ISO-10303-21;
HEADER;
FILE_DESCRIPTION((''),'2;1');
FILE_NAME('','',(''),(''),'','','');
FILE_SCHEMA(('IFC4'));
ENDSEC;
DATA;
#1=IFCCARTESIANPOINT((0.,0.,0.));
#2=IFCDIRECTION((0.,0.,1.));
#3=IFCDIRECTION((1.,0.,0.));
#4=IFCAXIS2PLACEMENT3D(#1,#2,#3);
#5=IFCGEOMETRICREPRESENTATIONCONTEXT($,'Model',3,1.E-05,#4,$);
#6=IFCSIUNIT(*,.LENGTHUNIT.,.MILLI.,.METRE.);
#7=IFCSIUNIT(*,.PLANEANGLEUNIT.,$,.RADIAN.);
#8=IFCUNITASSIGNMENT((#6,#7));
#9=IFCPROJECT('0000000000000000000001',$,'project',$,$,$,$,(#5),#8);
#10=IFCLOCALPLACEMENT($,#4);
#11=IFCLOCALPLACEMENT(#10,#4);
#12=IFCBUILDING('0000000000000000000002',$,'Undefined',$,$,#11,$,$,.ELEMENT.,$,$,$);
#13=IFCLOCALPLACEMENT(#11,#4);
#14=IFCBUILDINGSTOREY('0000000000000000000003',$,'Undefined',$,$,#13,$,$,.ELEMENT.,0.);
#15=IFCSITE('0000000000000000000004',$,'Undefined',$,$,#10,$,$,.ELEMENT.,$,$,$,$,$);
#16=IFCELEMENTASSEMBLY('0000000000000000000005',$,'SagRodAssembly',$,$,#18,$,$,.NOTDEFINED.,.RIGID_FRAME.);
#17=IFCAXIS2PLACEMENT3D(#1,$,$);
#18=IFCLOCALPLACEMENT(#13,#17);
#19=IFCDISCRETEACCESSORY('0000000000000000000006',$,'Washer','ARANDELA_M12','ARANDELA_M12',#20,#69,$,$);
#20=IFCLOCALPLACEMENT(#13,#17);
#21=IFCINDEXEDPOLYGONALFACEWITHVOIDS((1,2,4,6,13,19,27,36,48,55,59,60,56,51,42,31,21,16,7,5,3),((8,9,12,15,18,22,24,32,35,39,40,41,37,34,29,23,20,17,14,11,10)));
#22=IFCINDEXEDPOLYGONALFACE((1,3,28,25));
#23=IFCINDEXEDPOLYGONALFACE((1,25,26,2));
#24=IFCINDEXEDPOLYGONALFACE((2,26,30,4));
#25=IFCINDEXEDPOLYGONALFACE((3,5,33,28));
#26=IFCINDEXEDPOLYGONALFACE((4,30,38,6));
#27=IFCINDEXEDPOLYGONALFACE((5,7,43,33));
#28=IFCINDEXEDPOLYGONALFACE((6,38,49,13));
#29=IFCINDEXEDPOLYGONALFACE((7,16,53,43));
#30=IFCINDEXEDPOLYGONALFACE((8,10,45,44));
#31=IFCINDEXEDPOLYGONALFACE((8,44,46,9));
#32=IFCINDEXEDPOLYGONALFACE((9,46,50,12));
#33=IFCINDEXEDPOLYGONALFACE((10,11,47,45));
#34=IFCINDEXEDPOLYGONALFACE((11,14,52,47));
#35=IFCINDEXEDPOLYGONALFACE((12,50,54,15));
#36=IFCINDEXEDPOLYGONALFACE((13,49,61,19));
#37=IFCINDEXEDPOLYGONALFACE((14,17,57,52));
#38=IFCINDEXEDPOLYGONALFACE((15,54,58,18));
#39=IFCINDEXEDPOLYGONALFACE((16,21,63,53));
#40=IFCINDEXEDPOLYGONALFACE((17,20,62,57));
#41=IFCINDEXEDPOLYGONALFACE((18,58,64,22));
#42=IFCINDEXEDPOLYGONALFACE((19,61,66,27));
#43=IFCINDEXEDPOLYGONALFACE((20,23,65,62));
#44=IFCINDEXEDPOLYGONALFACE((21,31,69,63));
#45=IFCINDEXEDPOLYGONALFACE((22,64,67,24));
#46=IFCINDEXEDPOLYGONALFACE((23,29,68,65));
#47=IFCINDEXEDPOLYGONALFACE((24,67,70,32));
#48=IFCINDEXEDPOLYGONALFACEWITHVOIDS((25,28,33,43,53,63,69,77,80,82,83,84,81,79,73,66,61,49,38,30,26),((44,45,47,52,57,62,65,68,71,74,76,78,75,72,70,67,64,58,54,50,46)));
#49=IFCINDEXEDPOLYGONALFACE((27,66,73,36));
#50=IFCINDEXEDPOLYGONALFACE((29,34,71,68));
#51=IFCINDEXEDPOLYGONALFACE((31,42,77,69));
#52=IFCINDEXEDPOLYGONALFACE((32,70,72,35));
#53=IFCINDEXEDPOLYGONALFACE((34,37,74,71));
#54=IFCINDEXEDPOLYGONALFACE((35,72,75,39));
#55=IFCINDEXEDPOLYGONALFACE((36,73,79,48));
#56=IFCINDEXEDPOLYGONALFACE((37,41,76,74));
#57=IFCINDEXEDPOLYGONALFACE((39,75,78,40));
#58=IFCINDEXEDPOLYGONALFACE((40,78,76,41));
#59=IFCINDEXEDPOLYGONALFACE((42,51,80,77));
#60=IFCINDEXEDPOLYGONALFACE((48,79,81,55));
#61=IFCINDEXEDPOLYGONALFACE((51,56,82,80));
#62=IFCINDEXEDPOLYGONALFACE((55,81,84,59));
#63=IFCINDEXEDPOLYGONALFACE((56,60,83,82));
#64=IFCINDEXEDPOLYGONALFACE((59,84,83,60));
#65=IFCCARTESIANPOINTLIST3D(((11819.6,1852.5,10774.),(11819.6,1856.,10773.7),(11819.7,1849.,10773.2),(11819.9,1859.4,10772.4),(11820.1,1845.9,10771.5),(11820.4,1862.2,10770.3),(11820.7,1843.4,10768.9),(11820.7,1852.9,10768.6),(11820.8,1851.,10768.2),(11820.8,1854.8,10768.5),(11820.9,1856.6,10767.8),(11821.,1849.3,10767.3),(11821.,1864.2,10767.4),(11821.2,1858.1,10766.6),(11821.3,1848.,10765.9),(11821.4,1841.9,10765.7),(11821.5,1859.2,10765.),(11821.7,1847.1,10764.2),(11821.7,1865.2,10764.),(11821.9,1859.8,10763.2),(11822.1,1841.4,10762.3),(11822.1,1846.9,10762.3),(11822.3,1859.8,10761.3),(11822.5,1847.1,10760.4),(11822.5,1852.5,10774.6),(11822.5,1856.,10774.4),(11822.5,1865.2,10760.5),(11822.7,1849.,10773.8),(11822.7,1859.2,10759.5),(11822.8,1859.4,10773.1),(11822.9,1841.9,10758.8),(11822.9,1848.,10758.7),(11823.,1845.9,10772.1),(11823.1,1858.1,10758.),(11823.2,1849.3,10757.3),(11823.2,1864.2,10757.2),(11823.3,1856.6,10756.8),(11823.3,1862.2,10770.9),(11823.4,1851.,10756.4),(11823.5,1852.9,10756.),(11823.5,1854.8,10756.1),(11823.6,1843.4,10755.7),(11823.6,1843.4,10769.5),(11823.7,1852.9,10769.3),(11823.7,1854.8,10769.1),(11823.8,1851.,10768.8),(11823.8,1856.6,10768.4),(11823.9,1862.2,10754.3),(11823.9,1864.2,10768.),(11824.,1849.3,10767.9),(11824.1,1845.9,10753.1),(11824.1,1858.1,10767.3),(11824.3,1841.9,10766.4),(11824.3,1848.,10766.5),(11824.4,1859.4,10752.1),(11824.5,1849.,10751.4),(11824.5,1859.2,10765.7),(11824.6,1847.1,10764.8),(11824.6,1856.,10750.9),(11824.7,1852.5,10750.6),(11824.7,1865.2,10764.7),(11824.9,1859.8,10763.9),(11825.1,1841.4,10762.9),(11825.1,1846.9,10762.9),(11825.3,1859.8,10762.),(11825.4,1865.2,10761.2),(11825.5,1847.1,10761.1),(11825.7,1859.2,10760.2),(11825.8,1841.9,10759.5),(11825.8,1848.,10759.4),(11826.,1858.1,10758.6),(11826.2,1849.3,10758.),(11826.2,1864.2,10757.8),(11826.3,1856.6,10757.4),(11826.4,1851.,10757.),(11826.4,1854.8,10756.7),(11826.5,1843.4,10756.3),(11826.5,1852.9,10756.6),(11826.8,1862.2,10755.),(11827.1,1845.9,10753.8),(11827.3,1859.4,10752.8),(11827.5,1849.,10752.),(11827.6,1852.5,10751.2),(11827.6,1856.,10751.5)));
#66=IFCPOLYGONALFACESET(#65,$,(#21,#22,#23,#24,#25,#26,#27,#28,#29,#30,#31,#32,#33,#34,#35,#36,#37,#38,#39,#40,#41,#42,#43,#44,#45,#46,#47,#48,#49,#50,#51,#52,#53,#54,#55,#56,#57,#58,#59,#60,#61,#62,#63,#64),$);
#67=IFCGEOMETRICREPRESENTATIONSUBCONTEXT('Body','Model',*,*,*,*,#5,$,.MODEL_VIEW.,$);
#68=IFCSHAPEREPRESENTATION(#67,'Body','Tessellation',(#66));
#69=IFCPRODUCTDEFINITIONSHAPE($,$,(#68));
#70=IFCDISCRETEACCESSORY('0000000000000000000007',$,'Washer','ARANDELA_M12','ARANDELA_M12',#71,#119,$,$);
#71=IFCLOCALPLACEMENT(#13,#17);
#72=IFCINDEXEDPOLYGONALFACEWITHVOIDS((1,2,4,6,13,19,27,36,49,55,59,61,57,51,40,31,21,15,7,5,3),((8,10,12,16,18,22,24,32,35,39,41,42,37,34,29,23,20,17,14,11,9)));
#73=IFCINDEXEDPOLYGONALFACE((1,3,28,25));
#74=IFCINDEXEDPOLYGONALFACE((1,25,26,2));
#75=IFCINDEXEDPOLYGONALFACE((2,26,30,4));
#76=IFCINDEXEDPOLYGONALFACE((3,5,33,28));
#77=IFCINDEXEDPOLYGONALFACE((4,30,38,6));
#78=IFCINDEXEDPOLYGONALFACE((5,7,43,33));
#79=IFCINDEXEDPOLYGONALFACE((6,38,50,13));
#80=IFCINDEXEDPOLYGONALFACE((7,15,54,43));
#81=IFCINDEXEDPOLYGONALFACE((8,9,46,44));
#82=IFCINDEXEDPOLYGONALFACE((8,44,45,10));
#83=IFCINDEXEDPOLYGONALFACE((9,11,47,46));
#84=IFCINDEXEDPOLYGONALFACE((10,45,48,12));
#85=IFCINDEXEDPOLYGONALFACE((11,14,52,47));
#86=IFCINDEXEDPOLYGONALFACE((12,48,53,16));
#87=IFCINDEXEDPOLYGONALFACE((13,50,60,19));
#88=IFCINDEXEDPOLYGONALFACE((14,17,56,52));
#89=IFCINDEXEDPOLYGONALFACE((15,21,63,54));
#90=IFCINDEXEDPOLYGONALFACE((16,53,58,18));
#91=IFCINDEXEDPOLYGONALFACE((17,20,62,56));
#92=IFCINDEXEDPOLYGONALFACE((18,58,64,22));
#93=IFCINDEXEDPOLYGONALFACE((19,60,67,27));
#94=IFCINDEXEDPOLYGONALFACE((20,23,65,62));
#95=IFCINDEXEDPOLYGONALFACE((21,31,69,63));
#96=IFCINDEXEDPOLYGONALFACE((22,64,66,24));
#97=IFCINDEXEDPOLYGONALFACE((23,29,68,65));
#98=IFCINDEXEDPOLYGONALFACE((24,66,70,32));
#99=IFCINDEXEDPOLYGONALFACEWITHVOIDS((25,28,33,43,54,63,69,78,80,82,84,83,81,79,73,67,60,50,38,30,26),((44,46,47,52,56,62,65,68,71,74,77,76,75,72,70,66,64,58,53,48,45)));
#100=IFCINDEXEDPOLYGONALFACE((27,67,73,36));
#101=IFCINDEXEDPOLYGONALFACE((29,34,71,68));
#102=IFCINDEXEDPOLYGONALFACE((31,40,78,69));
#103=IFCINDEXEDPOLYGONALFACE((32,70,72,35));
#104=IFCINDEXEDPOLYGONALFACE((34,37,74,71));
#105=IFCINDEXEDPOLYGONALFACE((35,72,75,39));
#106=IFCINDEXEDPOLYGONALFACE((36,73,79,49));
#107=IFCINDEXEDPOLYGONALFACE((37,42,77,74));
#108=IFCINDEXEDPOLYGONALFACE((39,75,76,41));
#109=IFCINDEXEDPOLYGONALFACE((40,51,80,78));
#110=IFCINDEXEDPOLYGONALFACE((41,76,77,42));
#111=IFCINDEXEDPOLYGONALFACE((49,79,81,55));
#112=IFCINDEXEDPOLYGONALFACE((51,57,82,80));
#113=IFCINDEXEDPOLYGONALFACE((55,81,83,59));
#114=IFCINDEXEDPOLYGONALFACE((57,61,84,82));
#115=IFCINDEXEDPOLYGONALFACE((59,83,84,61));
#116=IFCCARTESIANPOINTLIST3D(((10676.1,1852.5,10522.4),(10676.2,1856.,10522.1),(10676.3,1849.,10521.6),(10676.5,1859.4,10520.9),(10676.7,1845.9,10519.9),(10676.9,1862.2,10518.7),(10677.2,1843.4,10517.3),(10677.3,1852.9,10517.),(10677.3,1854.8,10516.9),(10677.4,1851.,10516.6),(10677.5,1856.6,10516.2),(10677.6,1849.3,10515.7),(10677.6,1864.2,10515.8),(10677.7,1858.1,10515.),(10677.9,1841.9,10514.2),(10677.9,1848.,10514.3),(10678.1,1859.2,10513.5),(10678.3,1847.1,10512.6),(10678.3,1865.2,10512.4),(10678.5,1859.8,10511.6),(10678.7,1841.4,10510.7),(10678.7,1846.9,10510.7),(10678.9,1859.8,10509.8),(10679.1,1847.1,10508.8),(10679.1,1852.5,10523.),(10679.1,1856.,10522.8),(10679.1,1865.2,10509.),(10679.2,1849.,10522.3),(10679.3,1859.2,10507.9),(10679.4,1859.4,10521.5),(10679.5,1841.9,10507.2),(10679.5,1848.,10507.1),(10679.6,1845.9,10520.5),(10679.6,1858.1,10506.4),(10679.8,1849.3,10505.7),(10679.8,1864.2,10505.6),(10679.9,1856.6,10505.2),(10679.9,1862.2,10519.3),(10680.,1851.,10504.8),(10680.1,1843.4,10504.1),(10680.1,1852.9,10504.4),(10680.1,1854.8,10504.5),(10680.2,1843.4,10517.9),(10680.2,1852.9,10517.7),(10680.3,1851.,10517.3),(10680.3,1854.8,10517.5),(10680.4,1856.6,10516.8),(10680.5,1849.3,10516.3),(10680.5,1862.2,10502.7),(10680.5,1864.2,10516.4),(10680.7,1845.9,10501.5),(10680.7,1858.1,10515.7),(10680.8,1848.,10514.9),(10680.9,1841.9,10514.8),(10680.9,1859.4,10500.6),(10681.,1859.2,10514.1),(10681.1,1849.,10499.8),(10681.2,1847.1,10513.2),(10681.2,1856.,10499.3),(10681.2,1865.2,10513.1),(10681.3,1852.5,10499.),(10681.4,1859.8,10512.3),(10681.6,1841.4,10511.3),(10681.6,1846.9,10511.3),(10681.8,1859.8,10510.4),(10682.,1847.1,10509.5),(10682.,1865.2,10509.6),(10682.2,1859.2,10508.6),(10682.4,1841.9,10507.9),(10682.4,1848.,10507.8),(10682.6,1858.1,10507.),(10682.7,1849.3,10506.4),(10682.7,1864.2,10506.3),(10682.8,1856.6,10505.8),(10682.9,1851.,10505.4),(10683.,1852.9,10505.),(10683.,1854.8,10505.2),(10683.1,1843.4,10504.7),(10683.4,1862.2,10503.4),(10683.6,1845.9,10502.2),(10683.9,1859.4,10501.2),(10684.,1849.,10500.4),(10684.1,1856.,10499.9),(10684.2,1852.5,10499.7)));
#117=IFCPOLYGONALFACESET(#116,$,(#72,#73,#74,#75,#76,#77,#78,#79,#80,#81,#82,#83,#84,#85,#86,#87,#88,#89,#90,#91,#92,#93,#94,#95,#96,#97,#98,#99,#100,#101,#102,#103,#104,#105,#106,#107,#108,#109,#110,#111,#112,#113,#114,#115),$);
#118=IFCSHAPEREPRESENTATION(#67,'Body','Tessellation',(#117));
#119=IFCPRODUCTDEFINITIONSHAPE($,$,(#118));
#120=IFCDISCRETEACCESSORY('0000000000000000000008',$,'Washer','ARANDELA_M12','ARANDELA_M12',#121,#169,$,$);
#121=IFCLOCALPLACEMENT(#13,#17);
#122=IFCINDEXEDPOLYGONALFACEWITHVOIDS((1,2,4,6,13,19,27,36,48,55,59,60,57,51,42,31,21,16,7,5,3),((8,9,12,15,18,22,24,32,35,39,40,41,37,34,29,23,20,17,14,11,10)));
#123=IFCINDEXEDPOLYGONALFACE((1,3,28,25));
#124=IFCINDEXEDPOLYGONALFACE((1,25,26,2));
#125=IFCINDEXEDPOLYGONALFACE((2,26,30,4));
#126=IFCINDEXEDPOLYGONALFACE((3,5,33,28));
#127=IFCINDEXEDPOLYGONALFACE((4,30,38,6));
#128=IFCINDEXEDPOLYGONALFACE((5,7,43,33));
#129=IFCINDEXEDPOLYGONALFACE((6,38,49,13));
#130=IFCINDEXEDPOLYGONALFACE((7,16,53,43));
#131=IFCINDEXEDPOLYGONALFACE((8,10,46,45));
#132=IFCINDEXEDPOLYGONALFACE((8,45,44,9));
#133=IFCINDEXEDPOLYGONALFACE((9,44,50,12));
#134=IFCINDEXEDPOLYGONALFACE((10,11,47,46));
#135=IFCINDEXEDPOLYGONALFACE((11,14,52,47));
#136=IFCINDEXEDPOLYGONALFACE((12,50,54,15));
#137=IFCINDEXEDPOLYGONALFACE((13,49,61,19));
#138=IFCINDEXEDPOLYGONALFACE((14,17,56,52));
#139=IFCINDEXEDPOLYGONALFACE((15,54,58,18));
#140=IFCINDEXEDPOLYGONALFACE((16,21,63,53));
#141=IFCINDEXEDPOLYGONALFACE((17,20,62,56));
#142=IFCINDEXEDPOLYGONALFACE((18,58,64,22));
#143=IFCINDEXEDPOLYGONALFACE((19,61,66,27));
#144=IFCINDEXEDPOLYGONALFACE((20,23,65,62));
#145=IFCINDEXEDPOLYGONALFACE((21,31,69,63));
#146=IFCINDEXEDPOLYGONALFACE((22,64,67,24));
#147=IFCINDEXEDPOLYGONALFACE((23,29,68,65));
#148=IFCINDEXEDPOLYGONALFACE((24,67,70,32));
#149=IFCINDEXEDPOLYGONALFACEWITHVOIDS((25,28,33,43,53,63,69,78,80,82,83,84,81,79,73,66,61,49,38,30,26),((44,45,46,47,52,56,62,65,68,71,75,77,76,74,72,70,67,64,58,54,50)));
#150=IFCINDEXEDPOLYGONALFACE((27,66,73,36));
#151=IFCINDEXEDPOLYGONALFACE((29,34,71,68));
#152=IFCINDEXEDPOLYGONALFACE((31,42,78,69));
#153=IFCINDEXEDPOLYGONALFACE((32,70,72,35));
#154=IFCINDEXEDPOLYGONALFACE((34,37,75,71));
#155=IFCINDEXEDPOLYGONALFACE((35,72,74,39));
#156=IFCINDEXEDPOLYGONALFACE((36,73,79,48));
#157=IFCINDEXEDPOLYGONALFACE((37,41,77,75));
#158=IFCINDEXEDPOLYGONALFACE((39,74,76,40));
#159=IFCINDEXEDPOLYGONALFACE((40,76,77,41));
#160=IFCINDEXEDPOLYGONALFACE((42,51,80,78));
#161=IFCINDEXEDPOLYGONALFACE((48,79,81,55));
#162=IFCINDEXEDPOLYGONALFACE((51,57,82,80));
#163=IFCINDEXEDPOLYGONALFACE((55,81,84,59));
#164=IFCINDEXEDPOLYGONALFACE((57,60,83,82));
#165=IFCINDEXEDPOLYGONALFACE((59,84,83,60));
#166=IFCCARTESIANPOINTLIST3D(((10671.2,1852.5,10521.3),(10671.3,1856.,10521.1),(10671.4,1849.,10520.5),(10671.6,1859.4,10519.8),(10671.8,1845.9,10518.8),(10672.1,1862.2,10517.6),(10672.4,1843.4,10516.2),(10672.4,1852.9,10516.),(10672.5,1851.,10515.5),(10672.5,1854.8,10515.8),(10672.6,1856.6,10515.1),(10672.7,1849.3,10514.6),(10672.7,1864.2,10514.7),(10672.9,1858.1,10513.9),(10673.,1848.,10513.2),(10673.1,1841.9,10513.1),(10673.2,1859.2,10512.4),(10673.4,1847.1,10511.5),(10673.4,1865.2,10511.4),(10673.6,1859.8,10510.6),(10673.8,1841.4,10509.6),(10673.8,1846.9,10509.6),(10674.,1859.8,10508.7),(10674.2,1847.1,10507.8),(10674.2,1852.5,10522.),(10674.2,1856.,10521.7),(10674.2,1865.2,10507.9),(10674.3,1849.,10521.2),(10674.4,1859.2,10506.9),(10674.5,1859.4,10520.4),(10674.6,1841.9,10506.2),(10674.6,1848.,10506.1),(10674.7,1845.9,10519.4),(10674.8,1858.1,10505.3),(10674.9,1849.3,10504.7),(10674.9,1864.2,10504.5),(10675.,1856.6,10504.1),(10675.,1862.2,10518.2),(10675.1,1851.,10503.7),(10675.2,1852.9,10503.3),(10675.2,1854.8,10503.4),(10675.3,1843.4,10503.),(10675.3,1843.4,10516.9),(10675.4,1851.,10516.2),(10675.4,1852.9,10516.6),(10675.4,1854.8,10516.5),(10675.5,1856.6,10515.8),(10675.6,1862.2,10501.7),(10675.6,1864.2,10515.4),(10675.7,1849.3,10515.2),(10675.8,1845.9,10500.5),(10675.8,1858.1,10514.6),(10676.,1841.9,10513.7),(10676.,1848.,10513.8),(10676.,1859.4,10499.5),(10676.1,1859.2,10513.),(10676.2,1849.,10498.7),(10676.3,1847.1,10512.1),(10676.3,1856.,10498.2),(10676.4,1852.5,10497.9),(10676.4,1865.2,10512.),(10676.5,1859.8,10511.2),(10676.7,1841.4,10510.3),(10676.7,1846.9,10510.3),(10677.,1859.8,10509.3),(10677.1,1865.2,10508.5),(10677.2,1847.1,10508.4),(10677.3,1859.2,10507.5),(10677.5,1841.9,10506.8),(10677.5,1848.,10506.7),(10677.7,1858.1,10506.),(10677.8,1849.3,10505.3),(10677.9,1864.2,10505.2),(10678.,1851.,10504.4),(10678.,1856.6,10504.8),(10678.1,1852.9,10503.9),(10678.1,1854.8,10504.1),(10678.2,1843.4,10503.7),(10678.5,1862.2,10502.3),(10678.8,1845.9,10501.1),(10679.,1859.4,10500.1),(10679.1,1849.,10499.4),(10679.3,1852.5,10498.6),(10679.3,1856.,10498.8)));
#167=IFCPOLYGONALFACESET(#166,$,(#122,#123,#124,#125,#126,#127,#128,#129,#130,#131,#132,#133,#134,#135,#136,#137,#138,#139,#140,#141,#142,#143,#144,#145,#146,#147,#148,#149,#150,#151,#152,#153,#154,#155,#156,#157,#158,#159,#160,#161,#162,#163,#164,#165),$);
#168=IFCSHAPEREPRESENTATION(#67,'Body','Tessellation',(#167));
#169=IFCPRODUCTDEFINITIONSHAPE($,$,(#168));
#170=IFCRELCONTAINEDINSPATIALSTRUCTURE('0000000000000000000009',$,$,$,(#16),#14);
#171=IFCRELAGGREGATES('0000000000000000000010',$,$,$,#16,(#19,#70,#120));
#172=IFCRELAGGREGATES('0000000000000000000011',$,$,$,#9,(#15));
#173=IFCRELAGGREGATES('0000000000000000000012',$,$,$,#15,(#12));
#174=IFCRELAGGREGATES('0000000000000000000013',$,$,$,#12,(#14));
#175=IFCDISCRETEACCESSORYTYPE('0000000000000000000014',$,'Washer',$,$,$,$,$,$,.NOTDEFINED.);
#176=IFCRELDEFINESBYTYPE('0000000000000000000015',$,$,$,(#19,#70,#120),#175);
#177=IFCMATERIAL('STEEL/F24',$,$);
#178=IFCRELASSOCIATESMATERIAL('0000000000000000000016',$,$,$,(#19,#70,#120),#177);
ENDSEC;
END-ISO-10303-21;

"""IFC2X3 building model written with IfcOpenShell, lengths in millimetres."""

from ifc_helpers import new_model, si_unit, frame, origin_with_axes, origin_2d_with_axis, place, context, subcontext, project, spatial, hollow_circle, extrude, material, type_object, element, aggregate, save


model = new_model("IFC2X3")

# Units and contexts
model_context = context("Model", 3, precision=1e-05, world=origin_with_axes())
body_context = subcontext(model_context, "Body", "Model", "MODEL_VIEW")
ifc_project = project(units=[si_unit("LENGTHUNIT", "METRE", prefix="MILLI"), si_unit("PLANEANGLEUNIT", "RADIAN")], contexts=[model_context])

# Site, building, storey
site_placement = place(None, origin_with_axes())
site = spatial("IfcSite", under=ifc_project, at=site_placement, Name="Undefined", CompositionType="ELEMENT")
building_placement = place(site_placement, origin_with_axes())
building = spatial("IfcBuilding", under=site, at=building_placement, Name="Undefined", CompositionType="ELEMENT")
storey_placement = place(building_placement, origin_with_axes())
storey = spatial("IfcBuildingStorey", under=building, at=storey_placement, Name="Undefined", CompositionType="ELEMENT", Elevation=0.0)

# Shared definitions
ifc_material_1 = material(Name="STEEL/F24")

# Element assembly
assembly_1_placement = place(storey_placement, origin_with_axes())
assembly_1 = element("IfcElementAssembly", 1, at=assembly_1_placement, inside=storey, Name="SagRodAssembly", AssemblyPlace="NOTDEFINED", PredefinedType="RIGID_FRAME")

# Discrete accessories
discrete_accessory_type_1 = type_object("IfcDiscreteAccessoryType", Name="Washer")
discrete_accessory_1_placement = place(assembly_1_placement, frame((11822.1, 1853.4, 10762.3), z_axis=(-0.214887, 0.0, 0.976639), x_axis=(0.976639, 0.0, 0.214887)))
discrete_accessory_1 = element("IfcDiscreteAccessory", 2, at=discrete_accessory_1_placement, type_object=discrete_accessory_type_1, material=ifc_material_1, Name="Washer", Description="ARANDELA_M12", ObjectType="ARANDELA_M12", context=body_context, shape_type="SweptSolid", body=[
    extrude(hollow_circle(Radius=12.0, WallThickness=5.5, at=origin_2d_with_axis()), frame((3.0, 0.0, 0.0), z_axis=(-1.0, 0.0, 0.0), x_axis=(0.0, -1.0, 0.0)), (0.0, 0.0, 1.0), 3.0),
])
discrete_accessory_2_placement = place(assembly_1_placement, frame((10678.7, 1853.4, 10510.7), z_axis=(-0.214887, 0.0, 0.976639), x_axis=(0.976639, 0.0, 0.214887)))
discrete_accessory_2 = element("IfcDiscreteAccessory", 3, at=discrete_accessory_2_placement, type_object=discrete_accessory_type_1, material=ifc_material_1, Name="Washer", Description="ARANDELA_M12", ObjectType="ARANDELA_M12", context=body_context, shape_type="SweptSolid", body=[
    extrude(hollow_circle(Radius=12.0, WallThickness=5.5, at=origin_2d_with_axis()), frame((3.0, 0.0, 0.0), z_axis=(-1.0, 0.0, 0.0), x_axis=(0.0, -1.0, 0.0)), (0.0, 0.0, 1.0), 3.0),
])
discrete_accessory_3_placement = place(assembly_1_placement, frame((10673.8, 1853.4, 10509.6), z_axis=(-0.214887, 0.0, 0.976639), x_axis=(0.976639, 0.0, 0.214887)))
discrete_accessory_3 = element("IfcDiscreteAccessory", 4, at=discrete_accessory_3_placement, type_object=discrete_accessory_type_1, material=ifc_material_1, Name="Washer", Description="ARANDELA_M12", ObjectType="ARANDELA_M12", context=body_context, shape_type="SweptSolid", body=[
    extrude(hollow_circle(Radius=12.0, WallThickness=5.5, at=origin_2d_with_axis()), frame((3.0, 0.0, 0.0), z_axis=(-1.0, 0.0, 0.0), x_axis=(0.0, -1.0, 0.0)), (0.0, 0.0, 1.0), 3.0),
])
aggregate(assembly_1, [discrete_accessory_1, discrete_accessory_2, discrete_accessory_3])

save(model, "model.ifc")
